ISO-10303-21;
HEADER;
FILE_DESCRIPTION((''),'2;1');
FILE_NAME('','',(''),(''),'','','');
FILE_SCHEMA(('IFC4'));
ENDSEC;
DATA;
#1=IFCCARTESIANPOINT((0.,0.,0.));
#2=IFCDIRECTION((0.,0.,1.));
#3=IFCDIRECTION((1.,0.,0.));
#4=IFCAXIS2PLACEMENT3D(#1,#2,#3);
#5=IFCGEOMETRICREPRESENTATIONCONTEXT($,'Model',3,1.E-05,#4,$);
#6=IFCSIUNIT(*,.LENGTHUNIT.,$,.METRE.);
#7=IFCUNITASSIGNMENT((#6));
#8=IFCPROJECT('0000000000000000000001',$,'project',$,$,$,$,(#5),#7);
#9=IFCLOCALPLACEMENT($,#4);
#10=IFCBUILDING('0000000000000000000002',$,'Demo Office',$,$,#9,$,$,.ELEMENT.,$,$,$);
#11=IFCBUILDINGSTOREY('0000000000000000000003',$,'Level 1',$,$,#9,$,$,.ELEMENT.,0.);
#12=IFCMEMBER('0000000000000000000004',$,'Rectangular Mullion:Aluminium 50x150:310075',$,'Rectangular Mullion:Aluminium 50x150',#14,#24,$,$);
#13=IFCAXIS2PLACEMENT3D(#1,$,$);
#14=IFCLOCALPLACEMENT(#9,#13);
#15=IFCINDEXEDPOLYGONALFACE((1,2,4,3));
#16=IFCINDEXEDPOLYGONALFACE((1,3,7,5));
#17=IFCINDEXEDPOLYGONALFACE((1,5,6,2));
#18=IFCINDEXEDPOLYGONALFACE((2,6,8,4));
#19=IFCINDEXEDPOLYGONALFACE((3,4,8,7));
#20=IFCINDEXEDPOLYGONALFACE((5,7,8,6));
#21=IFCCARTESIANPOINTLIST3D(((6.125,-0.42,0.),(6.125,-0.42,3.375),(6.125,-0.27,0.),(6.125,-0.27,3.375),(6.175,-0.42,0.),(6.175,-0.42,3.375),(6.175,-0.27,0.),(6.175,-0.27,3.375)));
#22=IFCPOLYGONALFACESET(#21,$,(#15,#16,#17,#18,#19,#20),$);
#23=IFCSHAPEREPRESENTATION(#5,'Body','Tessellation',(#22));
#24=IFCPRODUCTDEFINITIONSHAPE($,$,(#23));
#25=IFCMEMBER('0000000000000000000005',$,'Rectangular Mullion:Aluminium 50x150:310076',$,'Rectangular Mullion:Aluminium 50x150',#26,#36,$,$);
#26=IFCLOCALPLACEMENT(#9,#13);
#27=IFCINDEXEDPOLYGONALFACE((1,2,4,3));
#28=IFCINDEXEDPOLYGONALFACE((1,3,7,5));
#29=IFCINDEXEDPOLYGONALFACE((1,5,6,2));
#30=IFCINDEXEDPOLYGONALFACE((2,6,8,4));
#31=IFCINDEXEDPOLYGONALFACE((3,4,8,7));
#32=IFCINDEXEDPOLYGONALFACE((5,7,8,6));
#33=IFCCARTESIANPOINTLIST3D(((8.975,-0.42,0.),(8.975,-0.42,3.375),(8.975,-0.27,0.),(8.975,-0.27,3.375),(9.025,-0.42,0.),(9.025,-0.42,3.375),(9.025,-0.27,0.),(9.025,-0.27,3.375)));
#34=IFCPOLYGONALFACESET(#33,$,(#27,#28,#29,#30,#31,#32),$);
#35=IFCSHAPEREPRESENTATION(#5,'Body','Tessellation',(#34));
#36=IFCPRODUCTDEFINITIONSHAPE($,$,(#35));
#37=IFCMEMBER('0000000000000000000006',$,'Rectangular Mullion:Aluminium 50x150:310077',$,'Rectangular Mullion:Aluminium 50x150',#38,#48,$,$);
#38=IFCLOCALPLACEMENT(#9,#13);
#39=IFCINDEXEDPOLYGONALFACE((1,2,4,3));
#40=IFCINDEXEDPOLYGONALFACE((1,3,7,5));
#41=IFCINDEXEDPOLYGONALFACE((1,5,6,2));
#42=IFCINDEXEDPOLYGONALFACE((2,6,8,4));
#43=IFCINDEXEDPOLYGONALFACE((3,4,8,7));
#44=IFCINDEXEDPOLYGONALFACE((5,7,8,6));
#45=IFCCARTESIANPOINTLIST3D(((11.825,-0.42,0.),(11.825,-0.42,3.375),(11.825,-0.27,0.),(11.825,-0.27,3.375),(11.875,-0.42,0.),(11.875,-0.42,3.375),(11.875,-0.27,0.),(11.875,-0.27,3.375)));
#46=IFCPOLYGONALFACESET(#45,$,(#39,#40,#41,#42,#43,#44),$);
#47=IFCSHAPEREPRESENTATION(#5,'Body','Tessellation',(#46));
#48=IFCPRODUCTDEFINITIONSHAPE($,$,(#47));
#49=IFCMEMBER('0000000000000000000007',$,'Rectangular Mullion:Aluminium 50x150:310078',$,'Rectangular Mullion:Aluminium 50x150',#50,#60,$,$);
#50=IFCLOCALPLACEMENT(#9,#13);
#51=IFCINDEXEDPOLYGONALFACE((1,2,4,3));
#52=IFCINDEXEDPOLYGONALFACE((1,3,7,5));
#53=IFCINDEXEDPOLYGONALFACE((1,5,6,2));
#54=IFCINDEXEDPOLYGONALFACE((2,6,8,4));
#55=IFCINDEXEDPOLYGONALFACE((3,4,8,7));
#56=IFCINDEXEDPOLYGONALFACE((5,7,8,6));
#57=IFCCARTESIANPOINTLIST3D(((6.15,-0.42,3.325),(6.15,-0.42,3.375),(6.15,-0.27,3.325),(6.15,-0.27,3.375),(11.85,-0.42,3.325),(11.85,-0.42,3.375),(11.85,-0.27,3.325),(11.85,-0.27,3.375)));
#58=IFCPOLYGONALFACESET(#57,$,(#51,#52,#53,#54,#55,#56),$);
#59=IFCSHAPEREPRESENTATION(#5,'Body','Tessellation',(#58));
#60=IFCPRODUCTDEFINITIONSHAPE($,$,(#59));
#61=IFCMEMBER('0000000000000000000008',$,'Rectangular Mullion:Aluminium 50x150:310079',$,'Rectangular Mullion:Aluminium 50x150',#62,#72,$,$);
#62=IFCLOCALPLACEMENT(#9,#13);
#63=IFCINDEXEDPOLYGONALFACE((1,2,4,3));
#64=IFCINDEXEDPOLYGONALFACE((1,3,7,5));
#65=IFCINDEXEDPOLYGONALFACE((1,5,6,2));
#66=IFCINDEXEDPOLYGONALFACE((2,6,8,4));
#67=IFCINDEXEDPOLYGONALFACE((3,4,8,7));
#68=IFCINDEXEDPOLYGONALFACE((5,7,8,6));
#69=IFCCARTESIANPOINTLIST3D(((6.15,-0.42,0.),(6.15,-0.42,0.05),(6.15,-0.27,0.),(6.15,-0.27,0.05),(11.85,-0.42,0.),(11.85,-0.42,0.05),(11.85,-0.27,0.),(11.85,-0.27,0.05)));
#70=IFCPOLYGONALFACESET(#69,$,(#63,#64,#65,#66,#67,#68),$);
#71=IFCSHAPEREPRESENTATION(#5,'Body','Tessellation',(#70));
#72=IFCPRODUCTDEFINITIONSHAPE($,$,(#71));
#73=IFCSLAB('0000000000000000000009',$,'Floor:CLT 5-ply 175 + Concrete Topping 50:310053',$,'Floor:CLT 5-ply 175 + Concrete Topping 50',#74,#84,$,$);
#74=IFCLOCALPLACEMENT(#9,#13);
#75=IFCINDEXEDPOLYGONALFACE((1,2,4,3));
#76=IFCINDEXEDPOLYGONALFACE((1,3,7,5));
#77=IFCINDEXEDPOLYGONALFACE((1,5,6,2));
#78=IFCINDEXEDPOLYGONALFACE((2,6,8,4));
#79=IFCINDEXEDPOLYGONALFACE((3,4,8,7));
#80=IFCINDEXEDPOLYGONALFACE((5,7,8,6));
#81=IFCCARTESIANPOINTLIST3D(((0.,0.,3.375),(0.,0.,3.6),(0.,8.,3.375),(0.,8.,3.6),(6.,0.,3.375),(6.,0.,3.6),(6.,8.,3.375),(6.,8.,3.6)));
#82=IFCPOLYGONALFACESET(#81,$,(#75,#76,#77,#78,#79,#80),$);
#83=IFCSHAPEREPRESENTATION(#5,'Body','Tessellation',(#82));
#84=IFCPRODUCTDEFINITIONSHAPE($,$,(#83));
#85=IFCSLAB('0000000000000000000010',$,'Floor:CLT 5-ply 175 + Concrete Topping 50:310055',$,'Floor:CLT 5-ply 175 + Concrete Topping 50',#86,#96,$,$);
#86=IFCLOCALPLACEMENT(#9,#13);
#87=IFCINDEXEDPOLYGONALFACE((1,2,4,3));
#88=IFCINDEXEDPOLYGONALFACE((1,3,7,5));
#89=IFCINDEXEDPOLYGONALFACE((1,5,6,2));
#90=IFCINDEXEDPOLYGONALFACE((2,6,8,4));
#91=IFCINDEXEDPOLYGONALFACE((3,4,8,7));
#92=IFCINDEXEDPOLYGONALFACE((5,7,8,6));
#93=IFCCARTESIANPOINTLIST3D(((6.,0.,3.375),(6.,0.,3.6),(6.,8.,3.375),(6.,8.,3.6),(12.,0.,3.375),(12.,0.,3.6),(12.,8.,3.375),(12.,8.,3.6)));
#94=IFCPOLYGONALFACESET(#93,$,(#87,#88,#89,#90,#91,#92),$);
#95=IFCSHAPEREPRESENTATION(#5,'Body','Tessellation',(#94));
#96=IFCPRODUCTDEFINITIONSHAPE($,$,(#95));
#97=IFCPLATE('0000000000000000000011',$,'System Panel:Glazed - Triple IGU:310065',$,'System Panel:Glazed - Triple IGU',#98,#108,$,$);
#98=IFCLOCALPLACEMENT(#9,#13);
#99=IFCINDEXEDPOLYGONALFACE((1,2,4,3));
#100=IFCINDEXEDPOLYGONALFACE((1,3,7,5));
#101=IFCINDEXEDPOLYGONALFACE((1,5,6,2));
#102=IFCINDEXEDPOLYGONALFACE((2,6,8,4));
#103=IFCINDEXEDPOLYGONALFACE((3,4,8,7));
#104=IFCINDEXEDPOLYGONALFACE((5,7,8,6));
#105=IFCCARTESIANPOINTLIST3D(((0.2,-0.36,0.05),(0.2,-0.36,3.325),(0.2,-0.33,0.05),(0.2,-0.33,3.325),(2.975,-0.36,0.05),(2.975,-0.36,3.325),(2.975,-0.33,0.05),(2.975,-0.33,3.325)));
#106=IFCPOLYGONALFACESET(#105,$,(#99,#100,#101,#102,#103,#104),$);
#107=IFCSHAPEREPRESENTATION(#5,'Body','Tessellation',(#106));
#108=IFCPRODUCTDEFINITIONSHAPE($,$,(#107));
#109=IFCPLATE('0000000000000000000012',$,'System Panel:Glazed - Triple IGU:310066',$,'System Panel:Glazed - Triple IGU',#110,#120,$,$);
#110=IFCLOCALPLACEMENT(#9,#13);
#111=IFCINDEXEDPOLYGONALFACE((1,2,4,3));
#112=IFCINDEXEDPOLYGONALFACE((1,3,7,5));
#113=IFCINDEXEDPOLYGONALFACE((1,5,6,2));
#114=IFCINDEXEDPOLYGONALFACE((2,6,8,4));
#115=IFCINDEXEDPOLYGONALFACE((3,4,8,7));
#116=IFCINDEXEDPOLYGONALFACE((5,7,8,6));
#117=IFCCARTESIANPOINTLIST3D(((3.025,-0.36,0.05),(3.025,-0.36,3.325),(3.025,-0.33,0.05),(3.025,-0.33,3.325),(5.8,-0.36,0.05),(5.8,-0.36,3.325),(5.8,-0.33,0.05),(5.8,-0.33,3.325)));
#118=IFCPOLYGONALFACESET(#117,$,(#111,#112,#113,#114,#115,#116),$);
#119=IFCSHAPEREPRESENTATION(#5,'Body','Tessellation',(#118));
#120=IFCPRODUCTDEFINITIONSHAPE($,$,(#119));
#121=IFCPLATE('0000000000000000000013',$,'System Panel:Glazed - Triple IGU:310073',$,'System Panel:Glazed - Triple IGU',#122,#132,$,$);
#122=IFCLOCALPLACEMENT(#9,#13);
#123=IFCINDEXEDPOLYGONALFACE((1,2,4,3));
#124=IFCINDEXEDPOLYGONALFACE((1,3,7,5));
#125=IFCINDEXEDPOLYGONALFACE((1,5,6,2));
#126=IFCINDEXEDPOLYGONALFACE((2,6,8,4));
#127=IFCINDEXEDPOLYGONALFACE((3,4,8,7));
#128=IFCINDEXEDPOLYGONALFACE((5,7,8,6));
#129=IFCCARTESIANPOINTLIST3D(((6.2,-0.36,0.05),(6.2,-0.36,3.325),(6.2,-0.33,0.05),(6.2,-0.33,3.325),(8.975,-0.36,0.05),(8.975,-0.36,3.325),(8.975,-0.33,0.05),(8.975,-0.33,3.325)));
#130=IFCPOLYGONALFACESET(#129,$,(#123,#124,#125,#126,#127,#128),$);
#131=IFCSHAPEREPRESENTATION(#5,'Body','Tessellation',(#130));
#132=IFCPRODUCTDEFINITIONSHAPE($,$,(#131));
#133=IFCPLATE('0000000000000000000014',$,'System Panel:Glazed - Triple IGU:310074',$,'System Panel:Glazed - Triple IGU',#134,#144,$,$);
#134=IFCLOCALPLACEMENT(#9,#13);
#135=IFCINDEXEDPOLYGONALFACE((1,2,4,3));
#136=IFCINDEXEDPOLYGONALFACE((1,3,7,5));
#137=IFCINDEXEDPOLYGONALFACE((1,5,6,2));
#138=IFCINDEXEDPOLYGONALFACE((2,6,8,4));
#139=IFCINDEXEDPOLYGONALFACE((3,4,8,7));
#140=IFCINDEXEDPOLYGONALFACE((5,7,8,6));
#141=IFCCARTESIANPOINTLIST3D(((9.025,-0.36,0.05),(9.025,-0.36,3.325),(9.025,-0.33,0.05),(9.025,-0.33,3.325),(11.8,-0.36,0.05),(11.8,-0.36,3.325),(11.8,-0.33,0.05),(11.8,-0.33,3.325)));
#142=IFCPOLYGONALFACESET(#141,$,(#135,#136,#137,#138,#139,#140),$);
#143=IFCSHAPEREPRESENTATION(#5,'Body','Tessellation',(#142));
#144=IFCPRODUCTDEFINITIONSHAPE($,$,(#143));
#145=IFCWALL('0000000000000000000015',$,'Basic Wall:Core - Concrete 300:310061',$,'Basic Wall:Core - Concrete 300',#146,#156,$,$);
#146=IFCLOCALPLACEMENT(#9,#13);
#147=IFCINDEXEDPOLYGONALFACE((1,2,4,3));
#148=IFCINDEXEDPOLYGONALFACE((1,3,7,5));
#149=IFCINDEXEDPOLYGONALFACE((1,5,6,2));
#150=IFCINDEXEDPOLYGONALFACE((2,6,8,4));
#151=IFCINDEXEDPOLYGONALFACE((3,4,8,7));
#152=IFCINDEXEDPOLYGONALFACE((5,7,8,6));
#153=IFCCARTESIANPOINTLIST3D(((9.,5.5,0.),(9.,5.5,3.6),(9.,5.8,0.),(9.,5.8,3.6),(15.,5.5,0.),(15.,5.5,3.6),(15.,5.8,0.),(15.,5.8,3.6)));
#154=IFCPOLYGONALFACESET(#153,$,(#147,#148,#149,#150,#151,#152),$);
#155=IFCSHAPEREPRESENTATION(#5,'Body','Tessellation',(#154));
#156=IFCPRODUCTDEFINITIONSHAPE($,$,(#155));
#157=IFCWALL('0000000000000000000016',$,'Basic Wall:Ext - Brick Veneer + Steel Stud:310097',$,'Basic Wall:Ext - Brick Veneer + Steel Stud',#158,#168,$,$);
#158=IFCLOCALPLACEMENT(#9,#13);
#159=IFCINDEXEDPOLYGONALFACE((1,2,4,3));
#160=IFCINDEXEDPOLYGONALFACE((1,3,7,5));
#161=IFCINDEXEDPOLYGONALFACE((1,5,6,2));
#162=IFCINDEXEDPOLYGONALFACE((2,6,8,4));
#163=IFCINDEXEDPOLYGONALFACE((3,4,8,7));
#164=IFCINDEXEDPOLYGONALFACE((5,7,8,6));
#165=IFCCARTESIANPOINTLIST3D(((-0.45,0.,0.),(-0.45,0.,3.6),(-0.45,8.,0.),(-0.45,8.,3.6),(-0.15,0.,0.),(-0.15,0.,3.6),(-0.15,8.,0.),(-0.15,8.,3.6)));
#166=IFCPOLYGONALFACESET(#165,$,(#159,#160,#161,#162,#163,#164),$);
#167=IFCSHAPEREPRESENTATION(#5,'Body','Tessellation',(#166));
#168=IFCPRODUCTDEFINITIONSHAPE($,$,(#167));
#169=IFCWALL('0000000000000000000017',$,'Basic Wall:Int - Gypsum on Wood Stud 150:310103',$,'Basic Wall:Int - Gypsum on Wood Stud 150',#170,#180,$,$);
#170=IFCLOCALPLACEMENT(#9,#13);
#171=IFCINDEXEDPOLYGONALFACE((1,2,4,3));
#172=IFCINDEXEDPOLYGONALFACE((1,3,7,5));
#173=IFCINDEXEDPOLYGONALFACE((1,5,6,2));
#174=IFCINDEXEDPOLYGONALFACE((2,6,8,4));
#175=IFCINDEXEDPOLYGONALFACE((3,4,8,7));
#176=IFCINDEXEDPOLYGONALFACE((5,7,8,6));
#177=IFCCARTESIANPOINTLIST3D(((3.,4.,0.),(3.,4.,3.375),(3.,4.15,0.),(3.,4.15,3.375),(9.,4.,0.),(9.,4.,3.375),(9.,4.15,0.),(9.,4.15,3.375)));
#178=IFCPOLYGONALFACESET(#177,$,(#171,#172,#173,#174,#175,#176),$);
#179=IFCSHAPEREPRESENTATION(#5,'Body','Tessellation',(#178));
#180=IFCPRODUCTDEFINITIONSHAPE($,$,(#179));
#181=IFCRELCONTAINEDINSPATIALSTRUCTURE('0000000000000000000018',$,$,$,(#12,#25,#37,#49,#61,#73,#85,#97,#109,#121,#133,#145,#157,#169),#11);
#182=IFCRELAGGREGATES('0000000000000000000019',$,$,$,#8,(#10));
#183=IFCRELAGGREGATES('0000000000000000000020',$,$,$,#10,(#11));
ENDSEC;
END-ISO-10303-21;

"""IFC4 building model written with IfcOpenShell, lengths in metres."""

from ifc_helpers import new_model, si_unit, frame, origin_with_axes, origin_2d, place, context, project, spatial, rectangle, extrude, element, save


model = new_model("IFC4")

# Units and contexts
model_context = context("Model", 3, precision=1e-05, world=origin_with_axes())
ifc_project = project(units=[si_unit("LENGTHUNIT", "METRE")], contexts=[model_context])

# Building, storey
placement = place(None, origin_with_axes())
building = spatial("IfcBuilding", under=ifc_project, at=placement, Name="Demo Office", CompositionType="ELEMENT")
storey = spatial("IfcBuildingStorey", under=building, at=placement, Name="Level 1", CompositionType="ELEMENT", Elevation=0.0)

# Members
for number, where, name in (
    (1, (6.15, -0.345, 0.0), "Rectangular Mullion:Aluminium 50x150:310075"),
    (2, (9.0, -0.345, 0.0), "Rectangular Mullion:Aluminium 50x150:310076"),
    (3, (11.85, -0.345, 0.0), "Rectangular Mullion:Aluminium 50x150:310077"),
):
    element("IfcMember", number, at=place(placement, frame(where)), inside=storey, Name=name, ObjectType="Rectangular Mullion:Aluminium 50x150", context=model_context, shape_type="SweptSolid", body=[
        extrude(rectangle(XDim=0.05, YDim=0.15, at=origin_2d()), origin_with_axes(), (0.0, 0.0, 1.0), 3.375),
    ])
for number, where, name in (
    (4, (9.0, -0.345, 3.325), "Rectangular Mullion:Aluminium 50x150:310078"),
    (5, (9.0, -0.345, 0.0), "Rectangular Mullion:Aluminium 50x150:310079"),
):
    element("IfcMember", number, at=place(placement, frame(where)), inside=storey, Name=name, ObjectType="Rectangular Mullion:Aluminium 50x150", context=model_context, shape_type="SweptSolid", body=[
        extrude(rectangle(XDim=5.7, YDim=0.15, at=origin_2d()), origin_with_axes(), (0.0, 0.0, 1.0), 0.05),
    ])

# Slabs
for number, where, name in (
    (6, (3.0, 4.0, 3.375), "Floor:CLT 5-ply 175 + Concrete Topping 50:310053"),
    (7, (9.0, 4.0, 3.375), "Floor:CLT 5-ply 175 + Concrete Topping 50:310055"),
):
    element("IfcSlab", number, at=place(placement, frame(where)), inside=storey, Name=name, ObjectType="Floor:CLT 5-ply 175 + Concrete Topping 50", context=model_context, shape_type="SweptSolid", body=[
        extrude(rectangle(XDim=6.0, YDim=8.0, at=origin_2d()), origin_with_axes(), (0.0, 0.0, 1.0), 0.225),
    ])

# Plates
for number, where, name in (
    (8, (1.5875, -0.345, 0.05), "System Panel:Glazed - Triple IGU:310065"),
    (9, (4.4125, -0.345, 0.05), "System Panel:Glazed - Triple IGU:310066"),
    (10, (7.5875, -0.345, 0.05), "System Panel:Glazed - Triple IGU:310073"),
    (11, (10.4125, -0.345, 0.05), "System Panel:Glazed - Triple IGU:310074"),
):
    element("IfcPlate", number, at=place(placement, frame(where)), inside=storey, Name=name, ObjectType="System Panel:Glazed - Triple IGU", context=model_context, shape_type="SweptSolid", body=[
        extrude(rectangle(XDim=2.775, YDim=0.03, at=origin_2d()), origin_with_axes(), (0.0, 0.0, 1.0), 3.275),
    ])

# Walls
wall_1_placement = place(placement, frame((12.0, 5.65, 0.0)))
element("IfcWall", 12, at=wall_1_placement, inside=storey, Name="Basic Wall:Core - Concrete 300:310061", ObjectType="Basic Wall:Core - Concrete 300", context=model_context, shape_type="SweptSolid", body=[
    extrude(rectangle(XDim=6.0, YDim=0.3, at=origin_2d()), origin_with_axes(), (0.0, 0.0, 1.0), 3.6),
])
wall_2_placement = place(placement, frame((-0.3, 4.0, 0.0)))
element("IfcWall", 13, at=wall_2_placement, inside=storey, Name="Basic Wall:Ext - Brick Veneer + Steel Stud:310097", ObjectType="Basic Wall:Ext - Brick Veneer + Steel Stud", context=model_context, shape_type="SweptSolid", body=[
    extrude(rectangle(XDim=0.3, YDim=8.0, at=origin_2d()), origin_with_axes(), (0.0, 0.0, 1.0), 3.6),
])
wall_3_placement = place(placement, frame((6.0, 4.075, 0.0)))
element("IfcWall", 14, at=wall_3_placement, inside=storey, Name="Basic Wall:Int - Gypsum on Wood Stud 150:310103", ObjectType="Basic Wall:Int - Gypsum on Wood Stud 150", context=model_context, shape_type="SweptSolid", body=[
    extrude(rectangle(XDim=6.0, YDim=0.15, at=origin_2d()), origin_with_axes(), (0.0, 0.0, 1.0), 3.375),
])

save(model, "model.ifc")
